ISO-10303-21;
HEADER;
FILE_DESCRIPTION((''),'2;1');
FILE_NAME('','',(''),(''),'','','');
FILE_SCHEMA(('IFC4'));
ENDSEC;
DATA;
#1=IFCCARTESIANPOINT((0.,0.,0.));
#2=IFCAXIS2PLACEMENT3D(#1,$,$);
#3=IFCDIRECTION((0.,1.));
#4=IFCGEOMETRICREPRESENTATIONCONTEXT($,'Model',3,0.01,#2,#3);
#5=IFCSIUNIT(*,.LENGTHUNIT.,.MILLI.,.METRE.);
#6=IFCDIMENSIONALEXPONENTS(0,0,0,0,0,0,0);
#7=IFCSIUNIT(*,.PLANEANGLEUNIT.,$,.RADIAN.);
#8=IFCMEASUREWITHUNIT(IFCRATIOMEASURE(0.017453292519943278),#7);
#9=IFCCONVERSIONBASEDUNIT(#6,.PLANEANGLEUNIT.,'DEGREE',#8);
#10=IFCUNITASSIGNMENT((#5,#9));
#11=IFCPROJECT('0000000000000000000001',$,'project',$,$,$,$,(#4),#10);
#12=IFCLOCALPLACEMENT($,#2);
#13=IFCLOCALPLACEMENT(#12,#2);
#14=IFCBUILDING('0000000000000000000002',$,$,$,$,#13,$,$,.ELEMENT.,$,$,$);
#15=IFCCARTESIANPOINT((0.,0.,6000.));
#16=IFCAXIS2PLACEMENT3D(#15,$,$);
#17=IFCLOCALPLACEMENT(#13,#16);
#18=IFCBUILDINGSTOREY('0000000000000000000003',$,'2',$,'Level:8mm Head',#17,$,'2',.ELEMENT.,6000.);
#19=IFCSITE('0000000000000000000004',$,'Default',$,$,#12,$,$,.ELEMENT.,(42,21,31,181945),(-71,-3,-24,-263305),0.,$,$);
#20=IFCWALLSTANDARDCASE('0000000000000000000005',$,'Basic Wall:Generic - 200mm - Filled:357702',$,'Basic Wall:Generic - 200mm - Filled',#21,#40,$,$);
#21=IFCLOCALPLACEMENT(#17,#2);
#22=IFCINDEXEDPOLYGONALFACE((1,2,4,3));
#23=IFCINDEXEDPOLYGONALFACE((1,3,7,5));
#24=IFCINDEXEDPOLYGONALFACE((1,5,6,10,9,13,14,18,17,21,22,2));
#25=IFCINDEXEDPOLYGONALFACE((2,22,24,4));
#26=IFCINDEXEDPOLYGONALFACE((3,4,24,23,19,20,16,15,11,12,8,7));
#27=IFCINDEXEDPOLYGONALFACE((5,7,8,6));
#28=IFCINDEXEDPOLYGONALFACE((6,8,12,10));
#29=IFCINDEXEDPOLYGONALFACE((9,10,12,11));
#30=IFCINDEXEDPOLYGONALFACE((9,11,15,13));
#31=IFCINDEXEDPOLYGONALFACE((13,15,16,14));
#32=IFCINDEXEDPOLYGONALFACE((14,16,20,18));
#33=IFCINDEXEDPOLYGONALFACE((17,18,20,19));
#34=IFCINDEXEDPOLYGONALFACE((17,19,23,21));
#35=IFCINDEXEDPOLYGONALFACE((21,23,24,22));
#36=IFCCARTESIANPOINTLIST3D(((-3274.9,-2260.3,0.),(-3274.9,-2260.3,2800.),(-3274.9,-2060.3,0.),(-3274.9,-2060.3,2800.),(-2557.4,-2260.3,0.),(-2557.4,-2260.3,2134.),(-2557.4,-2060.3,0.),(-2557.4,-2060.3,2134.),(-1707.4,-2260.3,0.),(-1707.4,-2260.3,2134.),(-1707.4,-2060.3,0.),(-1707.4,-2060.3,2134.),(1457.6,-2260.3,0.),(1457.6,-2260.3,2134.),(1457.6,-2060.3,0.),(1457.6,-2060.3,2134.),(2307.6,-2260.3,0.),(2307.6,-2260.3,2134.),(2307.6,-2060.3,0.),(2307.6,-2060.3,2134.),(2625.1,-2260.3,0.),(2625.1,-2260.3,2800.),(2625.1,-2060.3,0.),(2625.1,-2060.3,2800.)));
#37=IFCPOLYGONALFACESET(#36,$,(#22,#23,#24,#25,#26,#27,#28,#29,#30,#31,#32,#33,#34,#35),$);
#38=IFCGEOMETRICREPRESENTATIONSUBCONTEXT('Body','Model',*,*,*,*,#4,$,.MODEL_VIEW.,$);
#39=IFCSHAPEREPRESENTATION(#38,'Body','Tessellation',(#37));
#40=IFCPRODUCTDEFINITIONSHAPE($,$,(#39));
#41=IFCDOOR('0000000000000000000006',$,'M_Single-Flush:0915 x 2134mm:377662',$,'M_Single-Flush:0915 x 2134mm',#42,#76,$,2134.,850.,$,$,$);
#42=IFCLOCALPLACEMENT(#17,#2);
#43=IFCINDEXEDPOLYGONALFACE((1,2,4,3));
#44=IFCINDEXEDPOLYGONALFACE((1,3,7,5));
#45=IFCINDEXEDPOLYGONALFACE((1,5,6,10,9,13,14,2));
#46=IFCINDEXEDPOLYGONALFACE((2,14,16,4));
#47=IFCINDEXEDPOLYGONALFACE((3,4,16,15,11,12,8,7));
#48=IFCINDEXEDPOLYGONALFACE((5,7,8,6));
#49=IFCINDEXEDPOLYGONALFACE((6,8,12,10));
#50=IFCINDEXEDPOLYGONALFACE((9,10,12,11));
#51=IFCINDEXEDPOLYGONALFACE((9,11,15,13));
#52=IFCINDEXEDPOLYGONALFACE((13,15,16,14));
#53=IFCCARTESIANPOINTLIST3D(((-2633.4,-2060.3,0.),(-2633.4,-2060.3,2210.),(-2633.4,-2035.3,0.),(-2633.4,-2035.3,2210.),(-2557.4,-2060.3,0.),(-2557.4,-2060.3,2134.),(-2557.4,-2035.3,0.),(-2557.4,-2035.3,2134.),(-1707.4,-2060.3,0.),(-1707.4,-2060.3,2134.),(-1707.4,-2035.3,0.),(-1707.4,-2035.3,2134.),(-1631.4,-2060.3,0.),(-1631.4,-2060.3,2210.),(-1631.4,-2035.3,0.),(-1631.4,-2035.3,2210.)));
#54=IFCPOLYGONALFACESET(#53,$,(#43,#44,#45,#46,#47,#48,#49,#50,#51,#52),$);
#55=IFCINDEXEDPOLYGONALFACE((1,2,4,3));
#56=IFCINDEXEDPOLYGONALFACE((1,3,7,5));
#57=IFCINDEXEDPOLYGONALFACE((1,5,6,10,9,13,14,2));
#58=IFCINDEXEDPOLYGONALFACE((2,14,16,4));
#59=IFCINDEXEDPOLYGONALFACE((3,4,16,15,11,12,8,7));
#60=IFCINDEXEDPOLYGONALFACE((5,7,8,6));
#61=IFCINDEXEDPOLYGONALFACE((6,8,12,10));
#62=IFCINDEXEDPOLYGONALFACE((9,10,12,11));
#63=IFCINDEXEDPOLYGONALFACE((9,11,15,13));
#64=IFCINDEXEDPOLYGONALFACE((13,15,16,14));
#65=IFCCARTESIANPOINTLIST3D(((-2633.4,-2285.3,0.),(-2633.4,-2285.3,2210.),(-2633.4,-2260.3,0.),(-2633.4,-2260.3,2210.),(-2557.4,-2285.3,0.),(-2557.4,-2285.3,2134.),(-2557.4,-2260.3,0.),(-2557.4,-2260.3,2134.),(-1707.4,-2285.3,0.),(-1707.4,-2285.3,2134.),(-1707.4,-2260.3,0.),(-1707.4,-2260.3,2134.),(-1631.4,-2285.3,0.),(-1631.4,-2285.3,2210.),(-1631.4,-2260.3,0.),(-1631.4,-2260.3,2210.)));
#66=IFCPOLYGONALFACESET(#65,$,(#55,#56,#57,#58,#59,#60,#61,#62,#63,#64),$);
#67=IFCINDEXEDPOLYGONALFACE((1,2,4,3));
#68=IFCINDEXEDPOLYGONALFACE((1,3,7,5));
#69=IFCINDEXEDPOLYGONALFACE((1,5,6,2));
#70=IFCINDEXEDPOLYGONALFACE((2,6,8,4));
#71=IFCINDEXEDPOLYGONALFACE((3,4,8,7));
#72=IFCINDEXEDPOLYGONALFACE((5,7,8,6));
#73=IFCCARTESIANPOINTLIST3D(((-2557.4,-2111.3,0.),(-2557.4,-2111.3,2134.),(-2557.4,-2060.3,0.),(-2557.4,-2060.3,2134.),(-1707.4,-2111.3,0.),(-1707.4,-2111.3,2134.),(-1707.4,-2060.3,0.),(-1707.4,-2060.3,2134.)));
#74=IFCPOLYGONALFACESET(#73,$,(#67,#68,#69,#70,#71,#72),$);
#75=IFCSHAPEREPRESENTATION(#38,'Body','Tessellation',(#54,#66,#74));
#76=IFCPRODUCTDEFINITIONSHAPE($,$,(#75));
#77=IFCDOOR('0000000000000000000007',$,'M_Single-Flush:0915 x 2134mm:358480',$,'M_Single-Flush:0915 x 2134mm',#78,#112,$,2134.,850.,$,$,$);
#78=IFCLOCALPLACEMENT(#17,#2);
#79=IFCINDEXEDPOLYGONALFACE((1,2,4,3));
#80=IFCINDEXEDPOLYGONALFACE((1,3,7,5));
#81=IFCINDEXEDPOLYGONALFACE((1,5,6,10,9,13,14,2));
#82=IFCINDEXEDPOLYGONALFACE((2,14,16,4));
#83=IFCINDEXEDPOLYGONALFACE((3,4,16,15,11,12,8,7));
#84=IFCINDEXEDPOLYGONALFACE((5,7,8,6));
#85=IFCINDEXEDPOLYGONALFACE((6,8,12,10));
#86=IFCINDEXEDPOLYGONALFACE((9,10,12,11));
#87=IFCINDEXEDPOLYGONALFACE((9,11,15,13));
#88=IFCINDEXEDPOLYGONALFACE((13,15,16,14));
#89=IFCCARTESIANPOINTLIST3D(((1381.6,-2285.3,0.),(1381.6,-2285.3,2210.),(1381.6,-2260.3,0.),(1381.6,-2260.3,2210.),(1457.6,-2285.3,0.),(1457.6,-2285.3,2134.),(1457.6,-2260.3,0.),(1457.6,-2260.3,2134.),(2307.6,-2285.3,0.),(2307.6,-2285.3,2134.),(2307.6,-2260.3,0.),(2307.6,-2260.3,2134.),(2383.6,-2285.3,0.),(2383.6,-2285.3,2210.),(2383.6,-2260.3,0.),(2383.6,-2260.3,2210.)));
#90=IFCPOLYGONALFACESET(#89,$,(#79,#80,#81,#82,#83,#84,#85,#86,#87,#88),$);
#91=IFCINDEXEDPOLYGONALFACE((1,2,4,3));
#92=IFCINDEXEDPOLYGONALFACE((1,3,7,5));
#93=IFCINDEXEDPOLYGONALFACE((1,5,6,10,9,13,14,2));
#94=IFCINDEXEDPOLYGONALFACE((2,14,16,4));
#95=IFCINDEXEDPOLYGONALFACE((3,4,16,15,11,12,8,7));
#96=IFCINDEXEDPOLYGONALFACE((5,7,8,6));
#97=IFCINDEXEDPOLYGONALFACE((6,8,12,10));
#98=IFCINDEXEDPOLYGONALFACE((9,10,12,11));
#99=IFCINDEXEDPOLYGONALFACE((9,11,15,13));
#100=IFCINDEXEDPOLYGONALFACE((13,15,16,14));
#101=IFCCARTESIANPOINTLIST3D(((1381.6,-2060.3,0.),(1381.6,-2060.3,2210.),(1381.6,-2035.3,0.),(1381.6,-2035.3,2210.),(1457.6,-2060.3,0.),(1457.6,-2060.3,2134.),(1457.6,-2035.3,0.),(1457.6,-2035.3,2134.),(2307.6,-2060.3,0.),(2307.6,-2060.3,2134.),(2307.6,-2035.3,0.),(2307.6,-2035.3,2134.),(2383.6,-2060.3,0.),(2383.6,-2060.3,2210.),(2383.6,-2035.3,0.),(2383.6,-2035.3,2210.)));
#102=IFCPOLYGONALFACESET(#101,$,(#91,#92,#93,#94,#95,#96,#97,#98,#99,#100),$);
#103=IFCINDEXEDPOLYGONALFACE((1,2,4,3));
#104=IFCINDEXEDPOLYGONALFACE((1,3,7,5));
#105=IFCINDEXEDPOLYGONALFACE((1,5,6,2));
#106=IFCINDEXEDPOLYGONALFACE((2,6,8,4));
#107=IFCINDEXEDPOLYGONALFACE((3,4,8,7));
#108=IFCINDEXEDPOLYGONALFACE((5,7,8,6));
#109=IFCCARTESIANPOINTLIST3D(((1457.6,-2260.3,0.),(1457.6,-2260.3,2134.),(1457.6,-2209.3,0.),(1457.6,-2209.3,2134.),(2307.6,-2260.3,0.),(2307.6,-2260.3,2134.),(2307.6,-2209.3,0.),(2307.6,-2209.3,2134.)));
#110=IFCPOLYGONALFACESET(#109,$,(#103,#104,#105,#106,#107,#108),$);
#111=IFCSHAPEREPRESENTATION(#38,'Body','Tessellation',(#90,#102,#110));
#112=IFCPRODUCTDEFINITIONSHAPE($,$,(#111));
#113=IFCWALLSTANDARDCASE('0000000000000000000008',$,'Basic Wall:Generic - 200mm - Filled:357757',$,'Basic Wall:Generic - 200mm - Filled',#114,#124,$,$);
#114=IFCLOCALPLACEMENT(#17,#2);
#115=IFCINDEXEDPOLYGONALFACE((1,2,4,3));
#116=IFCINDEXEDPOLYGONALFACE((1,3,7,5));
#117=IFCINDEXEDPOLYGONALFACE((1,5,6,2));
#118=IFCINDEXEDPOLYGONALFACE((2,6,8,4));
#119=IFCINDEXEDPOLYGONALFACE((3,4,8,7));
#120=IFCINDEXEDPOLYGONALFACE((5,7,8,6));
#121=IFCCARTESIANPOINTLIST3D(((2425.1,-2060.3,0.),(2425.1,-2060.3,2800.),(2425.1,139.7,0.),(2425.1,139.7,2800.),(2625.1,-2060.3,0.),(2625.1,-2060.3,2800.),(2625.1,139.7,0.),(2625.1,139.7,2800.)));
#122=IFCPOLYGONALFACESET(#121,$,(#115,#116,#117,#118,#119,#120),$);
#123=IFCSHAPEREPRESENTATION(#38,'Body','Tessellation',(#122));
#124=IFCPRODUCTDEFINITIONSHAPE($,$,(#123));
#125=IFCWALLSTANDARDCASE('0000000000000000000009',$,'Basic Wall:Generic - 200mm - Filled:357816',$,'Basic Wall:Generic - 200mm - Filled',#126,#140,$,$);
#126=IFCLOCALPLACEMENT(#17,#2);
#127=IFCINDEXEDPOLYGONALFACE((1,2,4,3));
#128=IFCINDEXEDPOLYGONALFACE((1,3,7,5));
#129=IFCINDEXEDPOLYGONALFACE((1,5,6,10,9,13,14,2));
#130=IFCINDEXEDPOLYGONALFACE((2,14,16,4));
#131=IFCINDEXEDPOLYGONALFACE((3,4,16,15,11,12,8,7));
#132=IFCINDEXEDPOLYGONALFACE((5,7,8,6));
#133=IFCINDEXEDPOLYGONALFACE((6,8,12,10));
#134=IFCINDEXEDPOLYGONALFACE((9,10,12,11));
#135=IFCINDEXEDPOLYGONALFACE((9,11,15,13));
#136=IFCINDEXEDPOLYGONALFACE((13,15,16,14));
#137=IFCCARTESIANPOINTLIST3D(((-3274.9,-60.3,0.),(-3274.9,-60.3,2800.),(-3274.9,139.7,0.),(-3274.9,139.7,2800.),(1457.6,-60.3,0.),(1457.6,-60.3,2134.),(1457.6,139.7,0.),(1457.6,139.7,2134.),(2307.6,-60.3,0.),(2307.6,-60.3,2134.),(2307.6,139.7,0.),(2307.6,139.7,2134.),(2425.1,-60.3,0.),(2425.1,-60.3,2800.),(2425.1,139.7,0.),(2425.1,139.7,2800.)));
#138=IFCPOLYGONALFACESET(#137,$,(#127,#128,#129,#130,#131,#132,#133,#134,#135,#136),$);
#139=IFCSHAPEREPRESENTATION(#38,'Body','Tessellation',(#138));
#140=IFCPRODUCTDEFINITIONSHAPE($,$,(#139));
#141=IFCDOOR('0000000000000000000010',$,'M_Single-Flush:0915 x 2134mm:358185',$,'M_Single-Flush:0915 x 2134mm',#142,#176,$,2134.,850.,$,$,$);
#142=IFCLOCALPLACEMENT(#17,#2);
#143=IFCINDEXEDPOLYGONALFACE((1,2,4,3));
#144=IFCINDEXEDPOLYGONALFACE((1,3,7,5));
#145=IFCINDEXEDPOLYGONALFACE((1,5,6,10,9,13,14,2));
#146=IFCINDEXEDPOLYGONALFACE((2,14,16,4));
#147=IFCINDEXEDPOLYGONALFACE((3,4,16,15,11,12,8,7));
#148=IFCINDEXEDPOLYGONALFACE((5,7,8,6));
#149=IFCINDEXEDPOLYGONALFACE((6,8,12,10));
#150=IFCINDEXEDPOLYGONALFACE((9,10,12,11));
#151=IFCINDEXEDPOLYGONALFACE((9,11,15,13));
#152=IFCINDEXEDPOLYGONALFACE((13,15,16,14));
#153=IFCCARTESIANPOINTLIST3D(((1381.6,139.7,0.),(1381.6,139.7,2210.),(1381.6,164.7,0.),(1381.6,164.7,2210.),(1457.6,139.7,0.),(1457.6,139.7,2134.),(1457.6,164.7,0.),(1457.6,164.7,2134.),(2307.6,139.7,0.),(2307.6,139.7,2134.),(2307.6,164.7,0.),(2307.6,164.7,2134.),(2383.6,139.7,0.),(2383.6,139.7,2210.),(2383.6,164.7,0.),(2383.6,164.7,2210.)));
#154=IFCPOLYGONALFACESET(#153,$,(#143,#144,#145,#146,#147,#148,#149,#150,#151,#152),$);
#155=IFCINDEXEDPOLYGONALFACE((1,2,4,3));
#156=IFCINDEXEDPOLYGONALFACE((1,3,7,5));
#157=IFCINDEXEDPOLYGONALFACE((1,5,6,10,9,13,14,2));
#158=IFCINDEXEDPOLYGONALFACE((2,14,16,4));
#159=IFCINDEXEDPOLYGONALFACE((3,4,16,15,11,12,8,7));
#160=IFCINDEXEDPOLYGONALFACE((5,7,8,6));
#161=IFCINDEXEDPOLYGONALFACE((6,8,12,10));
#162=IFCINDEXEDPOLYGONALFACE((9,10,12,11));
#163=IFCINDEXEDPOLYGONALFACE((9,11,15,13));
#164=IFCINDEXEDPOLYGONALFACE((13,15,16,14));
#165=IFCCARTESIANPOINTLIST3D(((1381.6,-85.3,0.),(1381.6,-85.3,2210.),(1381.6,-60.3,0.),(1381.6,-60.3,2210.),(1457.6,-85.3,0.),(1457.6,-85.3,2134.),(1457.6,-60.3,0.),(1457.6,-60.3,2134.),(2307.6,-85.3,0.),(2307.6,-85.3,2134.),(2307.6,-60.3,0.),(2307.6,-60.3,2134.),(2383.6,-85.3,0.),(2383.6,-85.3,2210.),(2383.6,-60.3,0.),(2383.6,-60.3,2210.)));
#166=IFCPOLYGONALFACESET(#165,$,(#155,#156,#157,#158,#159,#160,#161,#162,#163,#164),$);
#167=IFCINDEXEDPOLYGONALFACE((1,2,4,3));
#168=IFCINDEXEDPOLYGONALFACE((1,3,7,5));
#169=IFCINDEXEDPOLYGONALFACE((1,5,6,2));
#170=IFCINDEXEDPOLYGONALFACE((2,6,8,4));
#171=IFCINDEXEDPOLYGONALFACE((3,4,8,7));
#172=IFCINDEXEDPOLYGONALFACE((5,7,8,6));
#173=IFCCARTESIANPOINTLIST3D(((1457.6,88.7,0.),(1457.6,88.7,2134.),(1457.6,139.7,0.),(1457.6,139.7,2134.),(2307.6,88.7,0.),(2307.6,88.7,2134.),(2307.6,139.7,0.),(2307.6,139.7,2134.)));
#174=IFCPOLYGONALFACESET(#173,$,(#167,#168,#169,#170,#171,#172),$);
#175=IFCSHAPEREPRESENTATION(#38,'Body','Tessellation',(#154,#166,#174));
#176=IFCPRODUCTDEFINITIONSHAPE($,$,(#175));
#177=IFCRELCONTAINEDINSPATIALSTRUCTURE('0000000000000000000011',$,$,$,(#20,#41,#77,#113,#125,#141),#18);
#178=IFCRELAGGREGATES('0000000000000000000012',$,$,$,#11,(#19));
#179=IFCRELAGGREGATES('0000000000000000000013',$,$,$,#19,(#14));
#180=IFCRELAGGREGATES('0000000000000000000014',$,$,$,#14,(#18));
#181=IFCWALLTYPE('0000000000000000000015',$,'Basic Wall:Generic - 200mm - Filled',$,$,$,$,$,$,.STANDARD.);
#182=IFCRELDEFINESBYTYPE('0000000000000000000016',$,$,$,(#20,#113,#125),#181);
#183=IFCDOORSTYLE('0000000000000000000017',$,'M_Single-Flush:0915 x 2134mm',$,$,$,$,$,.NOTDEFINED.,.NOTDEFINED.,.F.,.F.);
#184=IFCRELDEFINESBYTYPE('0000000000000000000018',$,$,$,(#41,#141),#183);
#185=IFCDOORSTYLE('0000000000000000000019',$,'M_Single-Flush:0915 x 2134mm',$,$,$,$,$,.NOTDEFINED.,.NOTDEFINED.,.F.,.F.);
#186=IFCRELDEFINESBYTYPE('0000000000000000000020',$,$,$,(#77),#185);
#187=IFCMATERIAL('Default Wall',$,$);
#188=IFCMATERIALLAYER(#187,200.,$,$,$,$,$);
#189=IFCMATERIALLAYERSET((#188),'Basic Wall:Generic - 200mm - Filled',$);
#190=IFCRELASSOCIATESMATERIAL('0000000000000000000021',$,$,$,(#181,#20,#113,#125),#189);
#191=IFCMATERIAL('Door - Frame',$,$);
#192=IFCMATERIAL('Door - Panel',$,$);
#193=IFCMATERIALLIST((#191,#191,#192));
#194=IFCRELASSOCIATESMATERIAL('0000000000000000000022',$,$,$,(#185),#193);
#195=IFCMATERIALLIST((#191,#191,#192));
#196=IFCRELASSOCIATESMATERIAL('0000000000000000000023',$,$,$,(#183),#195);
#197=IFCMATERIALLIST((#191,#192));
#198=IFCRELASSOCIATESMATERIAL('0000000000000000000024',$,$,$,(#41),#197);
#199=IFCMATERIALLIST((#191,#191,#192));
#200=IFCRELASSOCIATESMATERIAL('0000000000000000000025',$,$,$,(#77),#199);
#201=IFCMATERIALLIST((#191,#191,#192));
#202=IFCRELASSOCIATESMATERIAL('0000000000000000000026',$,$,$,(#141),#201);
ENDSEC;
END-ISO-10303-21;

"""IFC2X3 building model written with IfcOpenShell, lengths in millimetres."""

from ifc_helpers import new_model, entity, si_unit, converted_unit, direction, frame, frame_2d, origin, place, context, subcontext, project, spatial, polyline, rectangle, outline, extrude, source, transform, mapped, material, material_list, layer, layer_set, layer_usage, type_object, type_shapes, element, fill, save


model = new_model("IFC2X3")

# Units and contexts
model_context = context("Model", 3, precision=0.01, world=origin(), true_north=direction((0.0, 1.0)))
body_context = subcontext(model_context, "Body", "Model", "MODEL_VIEW")
ifc_project = project(units=[si_unit("LENGTHUNIT", "METRE", prefix="MILLI"), converted_unit("PLANEANGLEUNIT", "DEGREE", entity("IfcRatioMeasure", 0.017453292519943278), si_unit("PLANEANGLEUNIT", "RADIAN"), dimensions=[0, 0, 0, 0, 0, 0, 0])], contexts=[model_context])

# Site, building, storey
site_placement = place(None, origin())
site = spatial("IfcSite", under=ifc_project, at=site_placement, Name="Default", CompositionType="ELEMENT", RefLatitude=(42, 21, 31, 181945), RefLongitude=(-71, -3, -24, -263305), RefElevation=0.0)
building_placement = place(site_placement, origin())
building = spatial("IfcBuilding", under=site, at=building_placement, CompositionType="ELEMENT")
storey_placement = place(building_placement, frame((0.0, 0.0, 6000.0)))
storey = spatial("IfcBuildingStorey", under=building, at=storey_placement, Name="2", ObjectType="Level:8mm Head", LongName="2", CompositionType="ELEMENT", Elevation=6000.0)

# Shared definitions
ifc_material_1 = material(Name="Default Wall")
ifc_layer_1 = layer(ifc_material_1, 200.0)
ifc_layer_set_1 = layer_set([ifc_layer_1], Name="Basic Wall:Generic - 200mm - Filled")
wall_type_1 = type_object("IfcWallType", Name="Basic Wall:Generic - 200mm - Filled", PredefinedType="STANDARD", material=ifc_layer_set_1)
ifc_material_2 = material(Name="Door - Frame")
ifc_material_3 = material(Name="Door - Panel")
ifc_material_list_1 = material_list([ifc_material_2, ifc_material_2, ifc_material_3])
door_style_1 = type_object("IfcDoorStyle", Name="M_Single-Flush:0915 x 2134mm", ConstructionType="NOTDEFINED", OperationType="NOTDEFINED", ParameterTakesPrecedence=False, Sizeable=False, material=ifc_material_list_1)
shared_shape_1 = source(origin(), body_context, "Body", "SweptSolid", [
    extrude(outline(polyline([(-501.0, -1124.0), (501.0, -1124.0), (501.0, 1086.0), (425.0, 1086.0), (425.0, -1048.0), (-425.0, -1048.0), (-425.0, 1086.0), (-501.0, 1086.0), (-501.0, -1124.0)])), frame((425.0, 200.0, 1086.0), z_axis=(0.0, 1.0, 0.0), x_axis=(1.0, 0.0, 0.0)), (0.0, 0.0, 1.0), 25.0),
    extrude(outline(polyline([(-1124.0, -501.0), (1086.0, -501.0), (1086.0, -425.0), (-1048.0, -425.0), (-1048.0, 425.0), (1086.0, 425.0), (1086.0, 501.0), (-1124.0, 501.0), (-1124.0, -501.0)])), frame((425.0, -25.0, 1086.0), z_axis=(0.0, 1.0, 0.0), x_axis=(0.0, 0.0, -1.0)), (0.0, 0.0, 1.0), 25.0),
    extrude(rectangle(XDim=51.0, YDim=850.0, at=frame_2d((0.0, 0.0), x_axis=(1.0, 0.0))), frame((425.0, 174.5, 0.0), z_axis=(0.0, 0.0, 1.0), x_axis=(0.0, 1.0, 0.0)), (0.0, 0.0, 1.0), 2134.0),
])
type_shapes(door_style_1, [shared_shape_1])

# Wall, openings, doors
ifc_layer_usage_1 = layer_usage(ifc_layer_set_1, "AXIS2", "NEGATIVE", 100.0)
wall_1_placement = place(storey_placement, frame((-3274.9, -2160.3, 0.0)))
wall_1 = element("IfcWallStandardCase", 1, at=wall_1_placement, inside=storey, type_object=wall_type_1, material=ifc_layer_usage_1, Name="Basic Wall:Generic - 200mm - Filled:357702", ObjectType="Basic Wall:Generic - 200mm - Filled", context=body_context, shape_type="SweptSolid", body=[
    extrude(rectangle(XDim=5900.0, YDim=200.0, at=frame_2d((2950.0, 0.0), x_axis=(1.0, 0.0))), origin(), (0.0, 0.0, 1.0), 2800.0),
])
opening_1_placement = place(wall_1_placement, frame((5582.5, 100.0, 0.0)))
opening_1 = element("IfcOpeningElement", 2, at=opening_1_placement, cuts=wall_1, ObjectType="Opening", context=body_context, shape_type="SweptSolid", body=[
    extrude(rectangle(XDim=850.0, YDim=2134.0, at=frame_2d((1067.0, 425.0), x_axis=(0.0, 1.0))), frame((0.0, 0.0, 0.0), z_axis=(0.0, -1.0, 0.0), x_axis=(0.0, 0.0, 1.0)), (0.0, 0.0, 1.0), 200.0),
])
opening_2_placement = place(wall_1_placement, frame((717.5, -100.0, 0.0)))
opening_2 = element("IfcOpeningElement", 3, at=opening_2_placement, cuts=wall_1, ObjectType="Opening", context=body_context, shape_type="SweptSolid", body=[
    extrude(rectangle(XDim=850.0, YDim=2134.0, at=frame_2d((1067.0, 425.0), x_axis=(0.0, -1.0))), frame((0.0, 0.0, 0.0), z_axis=(0.0, 1.0, 0.0), x_axis=(0.0, 0.0, 1.0)), (0.0, 0.0, 1.0), 200.0),
])
ifc_material_list_2 = material_list([ifc_material_2, ifc_material_3])
ifc_material_list_3 = material_list([ifc_material_2, ifc_material_2, ifc_material_3])
door_style_2 = type_object("IfcDoorStyle", Name="M_Single-Flush:0915 x 2134mm", ConstructionType="NOTDEFINED", OperationType="NOTDEFINED", ParameterTakesPrecedence=False, Sizeable=False, material=ifc_material_list_3)
shared_shape_2 = source(origin(), body_context, "Body", "SweptSolid", [
    extrude(outline(polyline([(-501.0, -1124.0), (501.0, -1124.0), (501.0, 1086.0), (425.0, 1086.0), (425.0, -1048.0), (-425.0, -1048.0), (-425.0, 1086.0), (-501.0, 1086.0), (-501.0, -1124.0)])), frame((425.0, 225.0, 1086.0), z_axis=(0.0, -1.0, 0.0), x_axis=(-1.0, 0.0, 0.0)), (0.0, 0.0, 1.0), 25.0),
    extrude(outline(polyline([(-1124.0, -501.0), (1086.0, -501.0), (1086.0, -425.0), (-1048.0, -425.0), (-1048.0, 425.0), (1086.0, 425.0), (1086.0, 501.0), (-1124.0, 501.0), (-1124.0, -501.0)])), frame((425.0, 0.0, 1086.0), z_axis=(0.0, -1.0, 0.0), x_axis=(0.0, 0.0, -1.0)), (0.0, 0.0, 1.0), 25.0),
    extrude(rectangle(XDim=850.0, YDim=51.0, at=frame_2d((0.0, 0.0), x_axis=(1.0, 0.0))), frame((425.0, 174.5, 0.0)), (0.0, 0.0, 1.0), 2134.0),
])
type_shapes(door_style_2, [shared_shape_2])
door_1_placement = place(opening_2_placement, origin())
door_1 = element("IfcDoor", 4, at=door_1_placement, inside=storey, type_object=door_style_2, material=ifc_material_list_2, Name="M_Single-Flush:0915 x 2134mm:377662", ObjectType="M_Single-Flush:0915 x 2134mm", OverallHeight=2134.0, OverallWidth=850.0, context=body_context, shape_type="MappedRepresentation", body=[
    mapped(shared_shape_2, transform((0.0, 0.0, 0.0), scale=1.0)),
])
fill(opening_2, door_1)
ifc_material_list_4 = material_list([ifc_material_2, ifc_material_2, ifc_material_3])
door_2_placement = place(opening_1_placement, frame((0.0, 0.0, 0.0), z_axis=(0.0, 0.0, 1.0), x_axis=(-1.0, 0.0, 0.0)))
door_2 = element("IfcDoor", 5, at=door_2_placement, inside=storey, type_object=door_style_1, material=ifc_material_list_4, Name="M_Single-Flush:0915 x 2134mm:358480", ObjectType="M_Single-Flush:0915 x 2134mm", OverallHeight=2134.0, OverallWidth=850.0, context=body_context, shape_type="MappedRepresentation", body=[
    mapped(shared_shape_1, transform((0.0, 0.0, 0.0), scale=1.0)),
])
fill(opening_1, door_2)

# Wall
ifc_layer_usage_2 = layer_usage(ifc_layer_set_1, "AXIS2", "NEGATIVE", 100.0)
wall_2_placement = place(storey_placement, frame((2525.1, -2060.3, 0.0), z_axis=(0.0, 0.0, 1.0), x_axis=(0.0, 1.0, 0.0)))
element("IfcWallStandardCase", 6, at=wall_2_placement, inside=storey, type_object=wall_type_1, material=ifc_layer_usage_2, Name="Basic Wall:Generic - 200mm - Filled:357757", ObjectType="Basic Wall:Generic - 200mm - Filled", context=body_context, shape_type="SweptSolid", body=[
    extrude(rectangle(XDim=2200.0, YDim=200.0, at=frame_2d((1100.0, 0.0), x_axis=(-1.0, 0.0))), origin(), (0.0, 0.0, 1.0), 2800.0),
])

# Wall, opening, door
ifc_layer_usage_3 = layer_usage(ifc_layer_set_1, "AXIS2", "NEGATIVE", 100.0)
wall_3_placement = place(storey_placement, frame((2425.1, 39.7, 0.0), z_axis=(0.0, 0.0, 1.0), x_axis=(-1.0, 0.0, 0.0)))
wall_3 = element("IfcWallStandardCase", 7, at=wall_3_placement, inside=storey, type_object=wall_type_1, material=ifc_layer_usage_3, Name="Basic Wall:Generic - 200mm - Filled:357816", ObjectType="Basic Wall:Generic - 200mm - Filled", context=body_context, shape_type="SweptSolid", body=[
    extrude(rectangle(XDim=5700.0, YDim=200.0, at=frame_2d((2850.0, 0.0), x_axis=(1.0, 0.0))), origin(), (0.0, 0.0, 1.0), 2800.0),
])
opening_3_placement = place(wall_3_placement, frame((967.5, 100.0, 0.0)))
opening_3 = element("IfcOpeningElement", 8, at=opening_3_placement, cuts=wall_3, ObjectType="Opening", context=body_context, shape_type="SweptSolid", body=[
    extrude(rectangle(XDim=850.0, YDim=2134.0, at=frame_2d((1067.0, 425.0), x_axis=(0.0, -1.0))), frame((0.0, 0.0, 0.0), z_axis=(0.0, -1.0, 0.0), x_axis=(0.0, 0.0, 1.0)), (0.0, 0.0, 1.0), 200.0),
])
ifc_material_list_5 = material_list([ifc_material_2, ifc_material_2, ifc_material_3])
door_3_placement = place(opening_3_placement, frame((0.0, 0.0, 0.0), z_axis=(0.0, 0.0, 1.0), x_axis=(-1.0, 0.0, 0.0)))
door_3 = element("IfcDoor", 9, at=door_3_placement, inside=storey, type_object=door_style_2, material=ifc_material_list_5, Name="M_Single-Flush:0915 x 2134mm:358185", ObjectType="M_Single-Flush:0915 x 2134mm", OverallHeight=2134.0, OverallWidth=850.0, context=body_context, shape_type="MappedRepresentation", body=[
    mapped(shared_shape_2, transform((0.0, 0.0, 0.0), scale=1.0)),
])
fill(opening_3, door_3)

save(model, "model.ifc")
